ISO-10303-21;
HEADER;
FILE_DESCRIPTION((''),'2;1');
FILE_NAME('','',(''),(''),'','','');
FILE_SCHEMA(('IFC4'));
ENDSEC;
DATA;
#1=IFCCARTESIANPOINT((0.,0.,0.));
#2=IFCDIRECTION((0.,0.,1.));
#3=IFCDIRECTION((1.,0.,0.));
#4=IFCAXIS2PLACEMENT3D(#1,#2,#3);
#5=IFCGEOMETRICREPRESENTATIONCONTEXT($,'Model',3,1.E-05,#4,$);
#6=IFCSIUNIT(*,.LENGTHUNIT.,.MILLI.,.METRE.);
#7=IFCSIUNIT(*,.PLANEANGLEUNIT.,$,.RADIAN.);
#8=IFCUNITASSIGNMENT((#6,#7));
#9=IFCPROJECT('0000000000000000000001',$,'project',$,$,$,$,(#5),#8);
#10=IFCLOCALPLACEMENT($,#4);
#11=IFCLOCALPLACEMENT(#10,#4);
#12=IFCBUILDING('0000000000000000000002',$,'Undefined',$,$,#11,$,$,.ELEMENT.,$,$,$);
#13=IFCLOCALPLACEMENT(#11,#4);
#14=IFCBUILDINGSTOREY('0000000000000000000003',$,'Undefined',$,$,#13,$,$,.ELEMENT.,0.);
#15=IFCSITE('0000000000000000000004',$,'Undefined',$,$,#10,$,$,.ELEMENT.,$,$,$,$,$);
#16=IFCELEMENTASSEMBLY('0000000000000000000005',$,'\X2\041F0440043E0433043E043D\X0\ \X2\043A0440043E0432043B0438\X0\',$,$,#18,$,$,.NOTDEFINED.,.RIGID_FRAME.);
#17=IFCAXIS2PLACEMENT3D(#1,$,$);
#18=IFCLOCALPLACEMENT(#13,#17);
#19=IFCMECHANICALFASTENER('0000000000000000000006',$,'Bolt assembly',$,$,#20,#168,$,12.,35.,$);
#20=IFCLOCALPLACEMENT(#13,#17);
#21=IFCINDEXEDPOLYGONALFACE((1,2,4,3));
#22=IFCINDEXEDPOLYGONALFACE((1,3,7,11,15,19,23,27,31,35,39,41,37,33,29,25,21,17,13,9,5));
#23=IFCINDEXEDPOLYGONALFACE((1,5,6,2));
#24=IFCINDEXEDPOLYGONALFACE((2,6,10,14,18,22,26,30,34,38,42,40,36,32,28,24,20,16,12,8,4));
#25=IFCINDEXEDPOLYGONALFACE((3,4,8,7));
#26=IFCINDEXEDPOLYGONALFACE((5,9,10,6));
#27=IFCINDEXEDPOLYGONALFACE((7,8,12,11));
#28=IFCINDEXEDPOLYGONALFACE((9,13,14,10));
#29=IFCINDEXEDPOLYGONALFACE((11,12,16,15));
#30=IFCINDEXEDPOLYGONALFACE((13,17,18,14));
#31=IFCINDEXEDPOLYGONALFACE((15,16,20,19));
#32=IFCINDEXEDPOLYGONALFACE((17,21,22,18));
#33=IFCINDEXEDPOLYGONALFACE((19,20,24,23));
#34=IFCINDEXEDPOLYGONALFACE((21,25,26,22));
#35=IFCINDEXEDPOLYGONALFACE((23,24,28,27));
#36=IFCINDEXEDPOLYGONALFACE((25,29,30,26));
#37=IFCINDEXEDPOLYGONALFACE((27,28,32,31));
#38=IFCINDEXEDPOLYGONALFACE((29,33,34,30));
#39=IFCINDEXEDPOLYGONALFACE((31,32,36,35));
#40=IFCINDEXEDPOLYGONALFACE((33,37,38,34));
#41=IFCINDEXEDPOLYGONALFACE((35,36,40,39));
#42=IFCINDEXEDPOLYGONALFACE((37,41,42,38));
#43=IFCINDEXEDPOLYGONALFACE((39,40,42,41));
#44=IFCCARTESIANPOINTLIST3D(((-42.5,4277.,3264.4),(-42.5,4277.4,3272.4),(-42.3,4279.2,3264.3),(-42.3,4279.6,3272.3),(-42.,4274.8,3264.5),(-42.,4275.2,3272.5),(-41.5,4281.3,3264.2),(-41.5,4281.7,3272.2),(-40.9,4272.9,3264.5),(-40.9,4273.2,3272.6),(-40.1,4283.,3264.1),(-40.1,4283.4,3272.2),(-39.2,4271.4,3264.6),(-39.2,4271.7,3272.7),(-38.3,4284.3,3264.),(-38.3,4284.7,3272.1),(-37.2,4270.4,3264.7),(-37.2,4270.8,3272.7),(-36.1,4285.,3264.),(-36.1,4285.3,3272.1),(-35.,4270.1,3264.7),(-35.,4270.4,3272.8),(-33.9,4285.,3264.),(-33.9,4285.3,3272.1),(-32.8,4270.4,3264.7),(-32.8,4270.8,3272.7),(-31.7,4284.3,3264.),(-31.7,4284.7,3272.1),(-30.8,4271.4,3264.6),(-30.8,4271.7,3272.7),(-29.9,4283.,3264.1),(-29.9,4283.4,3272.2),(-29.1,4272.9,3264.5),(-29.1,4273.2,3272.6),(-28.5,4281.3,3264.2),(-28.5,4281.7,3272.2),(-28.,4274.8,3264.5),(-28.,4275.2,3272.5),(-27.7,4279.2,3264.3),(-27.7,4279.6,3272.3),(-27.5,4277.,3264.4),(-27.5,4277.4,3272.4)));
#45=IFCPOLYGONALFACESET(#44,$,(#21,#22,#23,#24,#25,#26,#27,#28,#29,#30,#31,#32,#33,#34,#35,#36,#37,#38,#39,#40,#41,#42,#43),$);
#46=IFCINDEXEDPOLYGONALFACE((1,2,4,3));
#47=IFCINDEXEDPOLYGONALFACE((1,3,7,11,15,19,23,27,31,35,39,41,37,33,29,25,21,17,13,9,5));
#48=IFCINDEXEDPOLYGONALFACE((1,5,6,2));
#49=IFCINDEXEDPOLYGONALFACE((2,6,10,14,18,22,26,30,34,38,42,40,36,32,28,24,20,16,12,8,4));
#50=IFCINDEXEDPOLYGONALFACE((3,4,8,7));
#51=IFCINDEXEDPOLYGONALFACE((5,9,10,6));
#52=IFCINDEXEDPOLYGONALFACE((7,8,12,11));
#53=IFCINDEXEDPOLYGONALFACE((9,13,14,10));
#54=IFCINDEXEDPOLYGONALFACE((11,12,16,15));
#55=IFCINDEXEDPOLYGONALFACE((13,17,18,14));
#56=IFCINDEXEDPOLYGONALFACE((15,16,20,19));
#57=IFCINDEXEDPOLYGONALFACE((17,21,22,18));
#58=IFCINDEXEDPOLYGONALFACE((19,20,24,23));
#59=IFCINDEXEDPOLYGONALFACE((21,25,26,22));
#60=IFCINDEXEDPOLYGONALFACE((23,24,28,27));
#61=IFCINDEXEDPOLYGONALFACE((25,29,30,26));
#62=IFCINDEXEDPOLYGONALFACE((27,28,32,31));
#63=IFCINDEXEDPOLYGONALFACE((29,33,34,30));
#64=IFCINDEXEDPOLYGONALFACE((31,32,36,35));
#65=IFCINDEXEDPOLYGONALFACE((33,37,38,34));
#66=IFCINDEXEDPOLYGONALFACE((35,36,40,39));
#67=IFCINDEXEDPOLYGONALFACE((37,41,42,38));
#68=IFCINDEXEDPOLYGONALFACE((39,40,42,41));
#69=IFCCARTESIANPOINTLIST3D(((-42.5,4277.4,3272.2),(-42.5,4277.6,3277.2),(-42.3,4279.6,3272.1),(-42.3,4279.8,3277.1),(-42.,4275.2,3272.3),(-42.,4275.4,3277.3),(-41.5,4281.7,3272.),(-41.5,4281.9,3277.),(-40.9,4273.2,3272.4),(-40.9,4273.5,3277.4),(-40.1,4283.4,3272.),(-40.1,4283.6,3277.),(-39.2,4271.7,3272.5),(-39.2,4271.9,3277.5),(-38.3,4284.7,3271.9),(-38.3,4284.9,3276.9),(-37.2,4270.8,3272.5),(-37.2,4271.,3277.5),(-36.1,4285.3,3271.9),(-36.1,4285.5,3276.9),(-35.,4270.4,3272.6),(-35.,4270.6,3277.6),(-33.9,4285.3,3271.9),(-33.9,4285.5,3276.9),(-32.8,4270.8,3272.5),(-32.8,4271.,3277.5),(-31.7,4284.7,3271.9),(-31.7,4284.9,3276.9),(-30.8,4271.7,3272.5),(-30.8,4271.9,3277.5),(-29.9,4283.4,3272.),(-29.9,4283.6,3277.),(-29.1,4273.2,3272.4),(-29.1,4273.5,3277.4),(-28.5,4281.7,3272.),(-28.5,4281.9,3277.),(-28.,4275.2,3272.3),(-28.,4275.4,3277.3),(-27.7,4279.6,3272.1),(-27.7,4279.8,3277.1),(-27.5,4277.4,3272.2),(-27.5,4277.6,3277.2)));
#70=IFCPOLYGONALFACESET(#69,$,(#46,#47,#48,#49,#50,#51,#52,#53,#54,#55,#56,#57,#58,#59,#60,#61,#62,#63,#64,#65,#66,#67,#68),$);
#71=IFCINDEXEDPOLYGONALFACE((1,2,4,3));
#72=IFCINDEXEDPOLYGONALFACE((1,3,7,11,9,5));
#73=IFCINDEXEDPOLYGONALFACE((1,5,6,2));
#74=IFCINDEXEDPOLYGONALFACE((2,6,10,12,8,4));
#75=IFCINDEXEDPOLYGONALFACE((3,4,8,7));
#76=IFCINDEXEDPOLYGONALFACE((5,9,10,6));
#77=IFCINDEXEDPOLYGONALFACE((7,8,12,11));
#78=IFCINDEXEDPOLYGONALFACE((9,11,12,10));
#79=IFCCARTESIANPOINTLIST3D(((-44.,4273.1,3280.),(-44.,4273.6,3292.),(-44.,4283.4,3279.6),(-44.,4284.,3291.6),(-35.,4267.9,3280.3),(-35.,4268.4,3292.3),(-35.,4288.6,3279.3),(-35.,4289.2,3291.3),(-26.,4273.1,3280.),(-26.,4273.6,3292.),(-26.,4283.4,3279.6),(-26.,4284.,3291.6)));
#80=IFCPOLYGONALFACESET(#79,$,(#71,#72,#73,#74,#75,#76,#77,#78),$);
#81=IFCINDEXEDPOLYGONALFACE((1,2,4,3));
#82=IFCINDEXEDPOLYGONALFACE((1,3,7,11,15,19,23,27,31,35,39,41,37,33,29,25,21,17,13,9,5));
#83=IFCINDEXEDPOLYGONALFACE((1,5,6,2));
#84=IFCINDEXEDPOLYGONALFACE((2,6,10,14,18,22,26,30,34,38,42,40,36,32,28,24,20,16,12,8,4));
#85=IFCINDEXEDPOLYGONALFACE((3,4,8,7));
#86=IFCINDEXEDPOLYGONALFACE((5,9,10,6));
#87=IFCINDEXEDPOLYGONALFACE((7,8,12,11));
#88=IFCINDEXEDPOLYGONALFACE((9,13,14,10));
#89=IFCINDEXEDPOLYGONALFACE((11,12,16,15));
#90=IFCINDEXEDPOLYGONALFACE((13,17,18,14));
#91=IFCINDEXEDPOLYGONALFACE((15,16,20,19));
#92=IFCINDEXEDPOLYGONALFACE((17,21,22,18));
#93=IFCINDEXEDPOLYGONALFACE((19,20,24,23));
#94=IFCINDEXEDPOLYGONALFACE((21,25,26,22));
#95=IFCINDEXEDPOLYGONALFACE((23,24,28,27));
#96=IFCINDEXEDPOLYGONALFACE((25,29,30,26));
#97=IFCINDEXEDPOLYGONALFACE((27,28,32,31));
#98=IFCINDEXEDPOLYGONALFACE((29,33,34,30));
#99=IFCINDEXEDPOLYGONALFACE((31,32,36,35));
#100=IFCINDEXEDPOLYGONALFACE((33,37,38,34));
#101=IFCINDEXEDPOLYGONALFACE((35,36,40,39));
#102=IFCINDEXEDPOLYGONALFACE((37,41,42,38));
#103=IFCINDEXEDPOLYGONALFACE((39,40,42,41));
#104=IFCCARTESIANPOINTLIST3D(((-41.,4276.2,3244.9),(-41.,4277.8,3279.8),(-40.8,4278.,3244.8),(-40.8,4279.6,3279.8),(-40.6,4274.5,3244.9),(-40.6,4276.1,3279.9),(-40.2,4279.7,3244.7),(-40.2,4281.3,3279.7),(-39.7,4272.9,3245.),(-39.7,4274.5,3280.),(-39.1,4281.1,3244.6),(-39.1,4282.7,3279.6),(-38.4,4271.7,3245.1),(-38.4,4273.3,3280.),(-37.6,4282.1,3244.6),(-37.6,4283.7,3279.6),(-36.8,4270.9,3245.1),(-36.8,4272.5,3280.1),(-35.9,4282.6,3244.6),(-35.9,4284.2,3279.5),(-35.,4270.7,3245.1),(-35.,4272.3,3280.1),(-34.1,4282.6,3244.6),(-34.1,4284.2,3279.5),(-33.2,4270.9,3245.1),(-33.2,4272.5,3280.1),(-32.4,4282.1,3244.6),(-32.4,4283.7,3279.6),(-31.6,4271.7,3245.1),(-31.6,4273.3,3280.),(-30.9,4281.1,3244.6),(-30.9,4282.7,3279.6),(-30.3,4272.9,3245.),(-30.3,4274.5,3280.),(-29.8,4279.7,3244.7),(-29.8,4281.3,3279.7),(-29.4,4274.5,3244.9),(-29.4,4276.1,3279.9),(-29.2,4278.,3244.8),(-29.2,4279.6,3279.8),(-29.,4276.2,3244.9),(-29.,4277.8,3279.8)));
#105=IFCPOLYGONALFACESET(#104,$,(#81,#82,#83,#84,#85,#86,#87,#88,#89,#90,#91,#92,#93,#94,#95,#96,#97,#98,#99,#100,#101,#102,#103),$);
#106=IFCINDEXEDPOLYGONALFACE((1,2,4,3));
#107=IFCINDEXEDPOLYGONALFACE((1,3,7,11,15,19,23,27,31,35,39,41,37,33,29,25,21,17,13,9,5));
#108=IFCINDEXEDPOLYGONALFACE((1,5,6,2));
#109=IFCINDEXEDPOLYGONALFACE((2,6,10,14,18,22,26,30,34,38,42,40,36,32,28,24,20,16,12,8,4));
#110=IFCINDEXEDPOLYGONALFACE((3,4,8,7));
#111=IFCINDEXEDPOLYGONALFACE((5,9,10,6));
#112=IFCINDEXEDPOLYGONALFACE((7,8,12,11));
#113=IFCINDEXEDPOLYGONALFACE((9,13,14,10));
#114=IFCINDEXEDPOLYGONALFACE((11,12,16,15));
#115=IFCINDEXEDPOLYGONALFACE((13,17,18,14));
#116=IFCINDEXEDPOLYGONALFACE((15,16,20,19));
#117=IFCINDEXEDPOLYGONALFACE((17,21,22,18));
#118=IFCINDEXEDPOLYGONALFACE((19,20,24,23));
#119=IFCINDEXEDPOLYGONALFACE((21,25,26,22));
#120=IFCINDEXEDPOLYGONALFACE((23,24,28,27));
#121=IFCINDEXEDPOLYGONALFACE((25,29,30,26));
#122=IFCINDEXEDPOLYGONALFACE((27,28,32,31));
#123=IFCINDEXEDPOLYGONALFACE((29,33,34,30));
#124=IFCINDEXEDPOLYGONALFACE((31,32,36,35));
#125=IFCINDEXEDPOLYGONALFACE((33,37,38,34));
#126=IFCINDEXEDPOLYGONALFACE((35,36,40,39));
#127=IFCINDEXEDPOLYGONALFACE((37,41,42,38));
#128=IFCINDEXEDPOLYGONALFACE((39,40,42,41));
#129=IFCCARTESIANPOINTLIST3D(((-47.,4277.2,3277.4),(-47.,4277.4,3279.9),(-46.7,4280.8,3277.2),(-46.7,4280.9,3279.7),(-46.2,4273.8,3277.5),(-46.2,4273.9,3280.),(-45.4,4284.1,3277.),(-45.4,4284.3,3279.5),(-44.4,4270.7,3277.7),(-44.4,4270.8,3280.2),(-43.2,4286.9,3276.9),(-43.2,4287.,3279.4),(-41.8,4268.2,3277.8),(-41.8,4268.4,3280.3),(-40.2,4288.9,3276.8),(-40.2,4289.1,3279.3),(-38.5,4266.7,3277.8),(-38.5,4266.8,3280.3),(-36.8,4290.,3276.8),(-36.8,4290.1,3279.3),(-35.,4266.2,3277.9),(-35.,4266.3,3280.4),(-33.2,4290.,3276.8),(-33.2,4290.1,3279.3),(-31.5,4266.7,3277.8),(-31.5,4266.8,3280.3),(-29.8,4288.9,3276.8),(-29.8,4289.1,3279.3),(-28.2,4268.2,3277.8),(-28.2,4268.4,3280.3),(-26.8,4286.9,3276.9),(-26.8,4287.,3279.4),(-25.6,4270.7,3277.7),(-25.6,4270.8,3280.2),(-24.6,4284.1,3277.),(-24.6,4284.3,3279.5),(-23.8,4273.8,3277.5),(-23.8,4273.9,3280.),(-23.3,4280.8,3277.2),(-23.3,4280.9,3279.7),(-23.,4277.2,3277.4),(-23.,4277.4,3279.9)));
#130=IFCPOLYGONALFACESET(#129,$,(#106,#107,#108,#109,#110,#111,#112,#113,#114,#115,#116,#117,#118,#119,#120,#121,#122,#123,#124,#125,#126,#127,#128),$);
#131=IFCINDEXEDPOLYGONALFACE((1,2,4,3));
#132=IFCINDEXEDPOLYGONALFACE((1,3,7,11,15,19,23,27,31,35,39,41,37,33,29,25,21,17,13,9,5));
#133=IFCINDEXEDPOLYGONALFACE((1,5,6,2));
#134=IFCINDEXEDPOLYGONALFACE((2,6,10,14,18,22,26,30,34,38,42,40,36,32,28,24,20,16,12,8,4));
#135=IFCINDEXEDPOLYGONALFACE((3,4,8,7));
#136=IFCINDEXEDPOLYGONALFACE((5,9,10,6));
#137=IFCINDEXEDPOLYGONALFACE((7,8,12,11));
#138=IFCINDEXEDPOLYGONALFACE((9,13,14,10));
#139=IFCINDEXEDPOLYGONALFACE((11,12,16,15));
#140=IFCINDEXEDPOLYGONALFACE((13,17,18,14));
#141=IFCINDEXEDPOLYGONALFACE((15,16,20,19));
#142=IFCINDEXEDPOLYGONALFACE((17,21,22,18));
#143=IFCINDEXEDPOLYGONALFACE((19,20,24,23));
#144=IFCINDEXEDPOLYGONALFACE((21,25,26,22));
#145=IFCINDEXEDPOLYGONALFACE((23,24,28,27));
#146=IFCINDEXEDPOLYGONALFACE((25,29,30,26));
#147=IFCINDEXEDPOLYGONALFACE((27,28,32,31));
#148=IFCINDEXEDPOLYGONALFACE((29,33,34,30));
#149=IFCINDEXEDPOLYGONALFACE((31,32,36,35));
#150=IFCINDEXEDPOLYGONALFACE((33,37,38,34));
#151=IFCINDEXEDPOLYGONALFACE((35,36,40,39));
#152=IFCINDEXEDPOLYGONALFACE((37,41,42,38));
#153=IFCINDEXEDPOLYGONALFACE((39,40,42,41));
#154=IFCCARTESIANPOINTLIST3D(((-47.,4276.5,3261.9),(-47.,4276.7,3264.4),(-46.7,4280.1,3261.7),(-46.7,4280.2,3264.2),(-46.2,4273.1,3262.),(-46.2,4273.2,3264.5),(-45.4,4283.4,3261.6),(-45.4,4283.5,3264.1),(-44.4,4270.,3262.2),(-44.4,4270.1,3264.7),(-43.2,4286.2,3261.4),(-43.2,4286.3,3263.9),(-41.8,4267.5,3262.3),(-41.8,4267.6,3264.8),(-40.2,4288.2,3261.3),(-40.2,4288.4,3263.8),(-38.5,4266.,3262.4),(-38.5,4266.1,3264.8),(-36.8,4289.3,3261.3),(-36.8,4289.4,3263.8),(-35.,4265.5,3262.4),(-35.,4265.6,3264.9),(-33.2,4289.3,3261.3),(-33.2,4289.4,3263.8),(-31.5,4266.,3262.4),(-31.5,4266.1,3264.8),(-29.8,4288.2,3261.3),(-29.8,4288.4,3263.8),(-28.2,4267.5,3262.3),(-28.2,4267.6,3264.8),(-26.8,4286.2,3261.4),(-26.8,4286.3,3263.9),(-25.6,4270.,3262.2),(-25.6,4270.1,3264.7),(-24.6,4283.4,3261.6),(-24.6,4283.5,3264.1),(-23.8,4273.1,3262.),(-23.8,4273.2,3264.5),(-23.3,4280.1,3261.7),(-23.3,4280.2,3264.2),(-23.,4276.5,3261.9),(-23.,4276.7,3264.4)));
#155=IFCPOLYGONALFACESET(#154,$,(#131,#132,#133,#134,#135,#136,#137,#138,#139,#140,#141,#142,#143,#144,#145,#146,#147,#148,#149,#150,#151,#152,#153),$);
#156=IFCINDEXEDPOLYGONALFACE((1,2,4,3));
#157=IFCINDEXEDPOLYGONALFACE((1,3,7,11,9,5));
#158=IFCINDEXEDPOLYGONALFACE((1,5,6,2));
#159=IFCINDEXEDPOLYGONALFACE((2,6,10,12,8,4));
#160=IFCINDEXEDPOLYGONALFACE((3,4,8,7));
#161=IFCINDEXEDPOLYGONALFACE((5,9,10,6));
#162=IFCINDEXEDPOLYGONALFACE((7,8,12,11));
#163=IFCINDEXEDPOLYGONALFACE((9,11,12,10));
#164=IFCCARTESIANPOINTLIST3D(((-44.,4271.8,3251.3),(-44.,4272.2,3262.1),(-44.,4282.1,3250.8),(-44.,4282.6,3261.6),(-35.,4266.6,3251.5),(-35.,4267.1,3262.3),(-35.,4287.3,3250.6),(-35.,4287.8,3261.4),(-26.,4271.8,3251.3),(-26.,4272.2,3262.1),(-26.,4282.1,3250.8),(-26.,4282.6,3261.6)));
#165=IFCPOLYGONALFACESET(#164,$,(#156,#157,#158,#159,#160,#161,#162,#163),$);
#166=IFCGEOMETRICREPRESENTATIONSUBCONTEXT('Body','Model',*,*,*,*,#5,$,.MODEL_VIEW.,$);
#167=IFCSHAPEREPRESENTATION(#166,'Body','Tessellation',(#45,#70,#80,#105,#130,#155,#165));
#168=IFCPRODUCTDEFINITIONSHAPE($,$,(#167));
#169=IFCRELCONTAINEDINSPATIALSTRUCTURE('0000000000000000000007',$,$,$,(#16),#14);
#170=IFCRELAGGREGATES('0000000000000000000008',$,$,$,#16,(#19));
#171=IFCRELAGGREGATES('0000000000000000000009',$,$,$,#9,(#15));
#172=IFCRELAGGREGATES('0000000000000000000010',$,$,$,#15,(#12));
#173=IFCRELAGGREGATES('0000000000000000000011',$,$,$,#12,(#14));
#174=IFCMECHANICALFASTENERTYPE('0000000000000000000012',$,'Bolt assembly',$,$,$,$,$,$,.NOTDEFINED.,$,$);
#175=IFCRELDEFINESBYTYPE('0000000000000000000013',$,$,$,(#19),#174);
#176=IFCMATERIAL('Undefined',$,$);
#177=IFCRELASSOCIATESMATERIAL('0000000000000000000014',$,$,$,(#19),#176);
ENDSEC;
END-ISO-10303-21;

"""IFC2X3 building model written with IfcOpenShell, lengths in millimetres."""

from ifc_helpers import new_model, si_unit, frame, origin_with_axes, origin_2d_with_axis, place, context, subcontext, project, spatial, polyline, circle, outline, extrude, source, transform, mapped, material, type_object, element, aggregate, save


model = new_model("IFC2X3")

# Units and contexts
model_context = context("Model", 3, precision=1e-05, world=origin_with_axes())
body_context = subcontext(model_context, "Body", "Model", "MODEL_VIEW")
ifc_project = project(units=[si_unit("LENGTHUNIT", "METRE", prefix="MILLI"), si_unit("PLANEANGLEUNIT", "RADIAN")], contexts=[model_context])

# Site, building, storey
site_placement = place(None, origin_with_axes())
site = spatial("IfcSite", under=ifc_project, at=site_placement, Name="Undefined", CompositionType="ELEMENT")
building_placement = place(site_placement, origin_with_axes())
building = spatial("IfcBuilding", under=site, at=building_placement, Name="Undefined", CompositionType="ELEMENT")
storey_placement = place(building_placement, origin_with_axes())
storey = spatial("IfcBuildingStorey", under=building, at=storey_placement, Name="Undefined", CompositionType="ELEMENT", Elevation=0.0)

# Element assembly
assembly_1_placement = place(storey_placement, origin_with_axes())
assembly_1 = element("IfcElementAssembly", 1, at=assembly_1_placement, inside=storey, Name="Прогон кровли", AssemblyPlace="NOTDEFINED", PredefinedType="RIGID_FRAME")

# Mechanical fastener
ifc_material_1 = material(Name="Undefined")
mechanical_fastener_type = type_object("IfcMechanicalFastenerType", Name="Bolt assembly")
shared_shape_1 = source(origin_with_axes(), body_context, "Body", "SweptSolid", [
    extrude(circle(Radius=7.5, at=origin_2d_with_axis()), frame((0.0, -0.1, 0.0), z_axis=(0.0, 1.0, 0.0), x_axis=(1.0, 0.0, 0.0)), (0.0, 0.0, 1.0), 8.1),
    extrude(circle(Radius=7.5, at=origin_2d_with_axis()), frame((0.0, -4.9, 0.0), z_axis=(0.0, 1.0, 0.0), x_axis=(1.0, 0.0, 0.0)), (0.0, 0.0, 1.0), 5.0),
    extrude(outline(polyline([(10.4, 0.0), (5.2, 9.0), (-5.2, 9.0), (-10.4, 0.0), (-5.2, -9.0), (5.2, -9.0), (10.4, 0.0)])), frame((0.0, -19.5, 0.0), z_axis=(0.0, 1.0, 0.0), x_axis=(1.0, 0.0, 0.0)), (0.0, 0.0, 1.0), 12.0),
    extrude(circle(Radius=6.0, at=origin_2d_with_axis()), frame((0.0, -7.5, 0.0), z_axis=(0.0, 1.0, 0.0), x_axis=(1.0, 0.0, 0.0)), (0.0, 0.0, 1.0), 35.0),
    extrude(circle(Radius=12.0, at=origin_2d_with_axis()), frame((0.0, -7.5, 0.0), z_axis=(0.0, 1.0, 0.0), x_axis=(1.0, 0.0, 0.0)), (0.0, 0.0, 1.0), 2.5),
    extrude(circle(Radius=12.0, at=origin_2d_with_axis()), frame((0.0, 8.0, 0.0), z_axis=(0.0, 1.0, 0.0), x_axis=(1.0, 0.0, 0.0)), (0.0, 0.0, 1.0), 2.5),
    extrude(outline(polyline([(10.4, 0.0), (5.2, 9.0), (-5.2, 9.0), (-10.4, 0.0), (-5.2, -9.0), (5.2, -9.0), (10.4, 0.0)])), frame((0.0, 10.5, 0.0), z_axis=(0.0, 1.0, 0.0), x_axis=(1.0, 0.0, 0.0)), (0.0, 0.0, 1.0), 10.8),
])
mechanical_fastener_1_placement = place(assembly_1_placement, frame((-35.0, 4277.9, 3272.3), z_axis=(1.0, 0.0, 0.0), x_axis=(0.0, -0.998969, 0.045408)))
mechanical_fastener_1 = element("IfcMechanicalFastener", 2, at=mechanical_fastener_1_placement, type_object=mechanical_fastener_type, material=ifc_material_1, Name="Bolt assembly", NominalDiameter=12.0, NominalLength=35.0, context=body_context, shape_type="MappedRepresentation", body=[
    mapped(shared_shape_1, transform((0.0, 0.0, 0.0))),
])
aggregate(assembly_1, [mechanical_fastener_1])

save(model, "model.ifc")
